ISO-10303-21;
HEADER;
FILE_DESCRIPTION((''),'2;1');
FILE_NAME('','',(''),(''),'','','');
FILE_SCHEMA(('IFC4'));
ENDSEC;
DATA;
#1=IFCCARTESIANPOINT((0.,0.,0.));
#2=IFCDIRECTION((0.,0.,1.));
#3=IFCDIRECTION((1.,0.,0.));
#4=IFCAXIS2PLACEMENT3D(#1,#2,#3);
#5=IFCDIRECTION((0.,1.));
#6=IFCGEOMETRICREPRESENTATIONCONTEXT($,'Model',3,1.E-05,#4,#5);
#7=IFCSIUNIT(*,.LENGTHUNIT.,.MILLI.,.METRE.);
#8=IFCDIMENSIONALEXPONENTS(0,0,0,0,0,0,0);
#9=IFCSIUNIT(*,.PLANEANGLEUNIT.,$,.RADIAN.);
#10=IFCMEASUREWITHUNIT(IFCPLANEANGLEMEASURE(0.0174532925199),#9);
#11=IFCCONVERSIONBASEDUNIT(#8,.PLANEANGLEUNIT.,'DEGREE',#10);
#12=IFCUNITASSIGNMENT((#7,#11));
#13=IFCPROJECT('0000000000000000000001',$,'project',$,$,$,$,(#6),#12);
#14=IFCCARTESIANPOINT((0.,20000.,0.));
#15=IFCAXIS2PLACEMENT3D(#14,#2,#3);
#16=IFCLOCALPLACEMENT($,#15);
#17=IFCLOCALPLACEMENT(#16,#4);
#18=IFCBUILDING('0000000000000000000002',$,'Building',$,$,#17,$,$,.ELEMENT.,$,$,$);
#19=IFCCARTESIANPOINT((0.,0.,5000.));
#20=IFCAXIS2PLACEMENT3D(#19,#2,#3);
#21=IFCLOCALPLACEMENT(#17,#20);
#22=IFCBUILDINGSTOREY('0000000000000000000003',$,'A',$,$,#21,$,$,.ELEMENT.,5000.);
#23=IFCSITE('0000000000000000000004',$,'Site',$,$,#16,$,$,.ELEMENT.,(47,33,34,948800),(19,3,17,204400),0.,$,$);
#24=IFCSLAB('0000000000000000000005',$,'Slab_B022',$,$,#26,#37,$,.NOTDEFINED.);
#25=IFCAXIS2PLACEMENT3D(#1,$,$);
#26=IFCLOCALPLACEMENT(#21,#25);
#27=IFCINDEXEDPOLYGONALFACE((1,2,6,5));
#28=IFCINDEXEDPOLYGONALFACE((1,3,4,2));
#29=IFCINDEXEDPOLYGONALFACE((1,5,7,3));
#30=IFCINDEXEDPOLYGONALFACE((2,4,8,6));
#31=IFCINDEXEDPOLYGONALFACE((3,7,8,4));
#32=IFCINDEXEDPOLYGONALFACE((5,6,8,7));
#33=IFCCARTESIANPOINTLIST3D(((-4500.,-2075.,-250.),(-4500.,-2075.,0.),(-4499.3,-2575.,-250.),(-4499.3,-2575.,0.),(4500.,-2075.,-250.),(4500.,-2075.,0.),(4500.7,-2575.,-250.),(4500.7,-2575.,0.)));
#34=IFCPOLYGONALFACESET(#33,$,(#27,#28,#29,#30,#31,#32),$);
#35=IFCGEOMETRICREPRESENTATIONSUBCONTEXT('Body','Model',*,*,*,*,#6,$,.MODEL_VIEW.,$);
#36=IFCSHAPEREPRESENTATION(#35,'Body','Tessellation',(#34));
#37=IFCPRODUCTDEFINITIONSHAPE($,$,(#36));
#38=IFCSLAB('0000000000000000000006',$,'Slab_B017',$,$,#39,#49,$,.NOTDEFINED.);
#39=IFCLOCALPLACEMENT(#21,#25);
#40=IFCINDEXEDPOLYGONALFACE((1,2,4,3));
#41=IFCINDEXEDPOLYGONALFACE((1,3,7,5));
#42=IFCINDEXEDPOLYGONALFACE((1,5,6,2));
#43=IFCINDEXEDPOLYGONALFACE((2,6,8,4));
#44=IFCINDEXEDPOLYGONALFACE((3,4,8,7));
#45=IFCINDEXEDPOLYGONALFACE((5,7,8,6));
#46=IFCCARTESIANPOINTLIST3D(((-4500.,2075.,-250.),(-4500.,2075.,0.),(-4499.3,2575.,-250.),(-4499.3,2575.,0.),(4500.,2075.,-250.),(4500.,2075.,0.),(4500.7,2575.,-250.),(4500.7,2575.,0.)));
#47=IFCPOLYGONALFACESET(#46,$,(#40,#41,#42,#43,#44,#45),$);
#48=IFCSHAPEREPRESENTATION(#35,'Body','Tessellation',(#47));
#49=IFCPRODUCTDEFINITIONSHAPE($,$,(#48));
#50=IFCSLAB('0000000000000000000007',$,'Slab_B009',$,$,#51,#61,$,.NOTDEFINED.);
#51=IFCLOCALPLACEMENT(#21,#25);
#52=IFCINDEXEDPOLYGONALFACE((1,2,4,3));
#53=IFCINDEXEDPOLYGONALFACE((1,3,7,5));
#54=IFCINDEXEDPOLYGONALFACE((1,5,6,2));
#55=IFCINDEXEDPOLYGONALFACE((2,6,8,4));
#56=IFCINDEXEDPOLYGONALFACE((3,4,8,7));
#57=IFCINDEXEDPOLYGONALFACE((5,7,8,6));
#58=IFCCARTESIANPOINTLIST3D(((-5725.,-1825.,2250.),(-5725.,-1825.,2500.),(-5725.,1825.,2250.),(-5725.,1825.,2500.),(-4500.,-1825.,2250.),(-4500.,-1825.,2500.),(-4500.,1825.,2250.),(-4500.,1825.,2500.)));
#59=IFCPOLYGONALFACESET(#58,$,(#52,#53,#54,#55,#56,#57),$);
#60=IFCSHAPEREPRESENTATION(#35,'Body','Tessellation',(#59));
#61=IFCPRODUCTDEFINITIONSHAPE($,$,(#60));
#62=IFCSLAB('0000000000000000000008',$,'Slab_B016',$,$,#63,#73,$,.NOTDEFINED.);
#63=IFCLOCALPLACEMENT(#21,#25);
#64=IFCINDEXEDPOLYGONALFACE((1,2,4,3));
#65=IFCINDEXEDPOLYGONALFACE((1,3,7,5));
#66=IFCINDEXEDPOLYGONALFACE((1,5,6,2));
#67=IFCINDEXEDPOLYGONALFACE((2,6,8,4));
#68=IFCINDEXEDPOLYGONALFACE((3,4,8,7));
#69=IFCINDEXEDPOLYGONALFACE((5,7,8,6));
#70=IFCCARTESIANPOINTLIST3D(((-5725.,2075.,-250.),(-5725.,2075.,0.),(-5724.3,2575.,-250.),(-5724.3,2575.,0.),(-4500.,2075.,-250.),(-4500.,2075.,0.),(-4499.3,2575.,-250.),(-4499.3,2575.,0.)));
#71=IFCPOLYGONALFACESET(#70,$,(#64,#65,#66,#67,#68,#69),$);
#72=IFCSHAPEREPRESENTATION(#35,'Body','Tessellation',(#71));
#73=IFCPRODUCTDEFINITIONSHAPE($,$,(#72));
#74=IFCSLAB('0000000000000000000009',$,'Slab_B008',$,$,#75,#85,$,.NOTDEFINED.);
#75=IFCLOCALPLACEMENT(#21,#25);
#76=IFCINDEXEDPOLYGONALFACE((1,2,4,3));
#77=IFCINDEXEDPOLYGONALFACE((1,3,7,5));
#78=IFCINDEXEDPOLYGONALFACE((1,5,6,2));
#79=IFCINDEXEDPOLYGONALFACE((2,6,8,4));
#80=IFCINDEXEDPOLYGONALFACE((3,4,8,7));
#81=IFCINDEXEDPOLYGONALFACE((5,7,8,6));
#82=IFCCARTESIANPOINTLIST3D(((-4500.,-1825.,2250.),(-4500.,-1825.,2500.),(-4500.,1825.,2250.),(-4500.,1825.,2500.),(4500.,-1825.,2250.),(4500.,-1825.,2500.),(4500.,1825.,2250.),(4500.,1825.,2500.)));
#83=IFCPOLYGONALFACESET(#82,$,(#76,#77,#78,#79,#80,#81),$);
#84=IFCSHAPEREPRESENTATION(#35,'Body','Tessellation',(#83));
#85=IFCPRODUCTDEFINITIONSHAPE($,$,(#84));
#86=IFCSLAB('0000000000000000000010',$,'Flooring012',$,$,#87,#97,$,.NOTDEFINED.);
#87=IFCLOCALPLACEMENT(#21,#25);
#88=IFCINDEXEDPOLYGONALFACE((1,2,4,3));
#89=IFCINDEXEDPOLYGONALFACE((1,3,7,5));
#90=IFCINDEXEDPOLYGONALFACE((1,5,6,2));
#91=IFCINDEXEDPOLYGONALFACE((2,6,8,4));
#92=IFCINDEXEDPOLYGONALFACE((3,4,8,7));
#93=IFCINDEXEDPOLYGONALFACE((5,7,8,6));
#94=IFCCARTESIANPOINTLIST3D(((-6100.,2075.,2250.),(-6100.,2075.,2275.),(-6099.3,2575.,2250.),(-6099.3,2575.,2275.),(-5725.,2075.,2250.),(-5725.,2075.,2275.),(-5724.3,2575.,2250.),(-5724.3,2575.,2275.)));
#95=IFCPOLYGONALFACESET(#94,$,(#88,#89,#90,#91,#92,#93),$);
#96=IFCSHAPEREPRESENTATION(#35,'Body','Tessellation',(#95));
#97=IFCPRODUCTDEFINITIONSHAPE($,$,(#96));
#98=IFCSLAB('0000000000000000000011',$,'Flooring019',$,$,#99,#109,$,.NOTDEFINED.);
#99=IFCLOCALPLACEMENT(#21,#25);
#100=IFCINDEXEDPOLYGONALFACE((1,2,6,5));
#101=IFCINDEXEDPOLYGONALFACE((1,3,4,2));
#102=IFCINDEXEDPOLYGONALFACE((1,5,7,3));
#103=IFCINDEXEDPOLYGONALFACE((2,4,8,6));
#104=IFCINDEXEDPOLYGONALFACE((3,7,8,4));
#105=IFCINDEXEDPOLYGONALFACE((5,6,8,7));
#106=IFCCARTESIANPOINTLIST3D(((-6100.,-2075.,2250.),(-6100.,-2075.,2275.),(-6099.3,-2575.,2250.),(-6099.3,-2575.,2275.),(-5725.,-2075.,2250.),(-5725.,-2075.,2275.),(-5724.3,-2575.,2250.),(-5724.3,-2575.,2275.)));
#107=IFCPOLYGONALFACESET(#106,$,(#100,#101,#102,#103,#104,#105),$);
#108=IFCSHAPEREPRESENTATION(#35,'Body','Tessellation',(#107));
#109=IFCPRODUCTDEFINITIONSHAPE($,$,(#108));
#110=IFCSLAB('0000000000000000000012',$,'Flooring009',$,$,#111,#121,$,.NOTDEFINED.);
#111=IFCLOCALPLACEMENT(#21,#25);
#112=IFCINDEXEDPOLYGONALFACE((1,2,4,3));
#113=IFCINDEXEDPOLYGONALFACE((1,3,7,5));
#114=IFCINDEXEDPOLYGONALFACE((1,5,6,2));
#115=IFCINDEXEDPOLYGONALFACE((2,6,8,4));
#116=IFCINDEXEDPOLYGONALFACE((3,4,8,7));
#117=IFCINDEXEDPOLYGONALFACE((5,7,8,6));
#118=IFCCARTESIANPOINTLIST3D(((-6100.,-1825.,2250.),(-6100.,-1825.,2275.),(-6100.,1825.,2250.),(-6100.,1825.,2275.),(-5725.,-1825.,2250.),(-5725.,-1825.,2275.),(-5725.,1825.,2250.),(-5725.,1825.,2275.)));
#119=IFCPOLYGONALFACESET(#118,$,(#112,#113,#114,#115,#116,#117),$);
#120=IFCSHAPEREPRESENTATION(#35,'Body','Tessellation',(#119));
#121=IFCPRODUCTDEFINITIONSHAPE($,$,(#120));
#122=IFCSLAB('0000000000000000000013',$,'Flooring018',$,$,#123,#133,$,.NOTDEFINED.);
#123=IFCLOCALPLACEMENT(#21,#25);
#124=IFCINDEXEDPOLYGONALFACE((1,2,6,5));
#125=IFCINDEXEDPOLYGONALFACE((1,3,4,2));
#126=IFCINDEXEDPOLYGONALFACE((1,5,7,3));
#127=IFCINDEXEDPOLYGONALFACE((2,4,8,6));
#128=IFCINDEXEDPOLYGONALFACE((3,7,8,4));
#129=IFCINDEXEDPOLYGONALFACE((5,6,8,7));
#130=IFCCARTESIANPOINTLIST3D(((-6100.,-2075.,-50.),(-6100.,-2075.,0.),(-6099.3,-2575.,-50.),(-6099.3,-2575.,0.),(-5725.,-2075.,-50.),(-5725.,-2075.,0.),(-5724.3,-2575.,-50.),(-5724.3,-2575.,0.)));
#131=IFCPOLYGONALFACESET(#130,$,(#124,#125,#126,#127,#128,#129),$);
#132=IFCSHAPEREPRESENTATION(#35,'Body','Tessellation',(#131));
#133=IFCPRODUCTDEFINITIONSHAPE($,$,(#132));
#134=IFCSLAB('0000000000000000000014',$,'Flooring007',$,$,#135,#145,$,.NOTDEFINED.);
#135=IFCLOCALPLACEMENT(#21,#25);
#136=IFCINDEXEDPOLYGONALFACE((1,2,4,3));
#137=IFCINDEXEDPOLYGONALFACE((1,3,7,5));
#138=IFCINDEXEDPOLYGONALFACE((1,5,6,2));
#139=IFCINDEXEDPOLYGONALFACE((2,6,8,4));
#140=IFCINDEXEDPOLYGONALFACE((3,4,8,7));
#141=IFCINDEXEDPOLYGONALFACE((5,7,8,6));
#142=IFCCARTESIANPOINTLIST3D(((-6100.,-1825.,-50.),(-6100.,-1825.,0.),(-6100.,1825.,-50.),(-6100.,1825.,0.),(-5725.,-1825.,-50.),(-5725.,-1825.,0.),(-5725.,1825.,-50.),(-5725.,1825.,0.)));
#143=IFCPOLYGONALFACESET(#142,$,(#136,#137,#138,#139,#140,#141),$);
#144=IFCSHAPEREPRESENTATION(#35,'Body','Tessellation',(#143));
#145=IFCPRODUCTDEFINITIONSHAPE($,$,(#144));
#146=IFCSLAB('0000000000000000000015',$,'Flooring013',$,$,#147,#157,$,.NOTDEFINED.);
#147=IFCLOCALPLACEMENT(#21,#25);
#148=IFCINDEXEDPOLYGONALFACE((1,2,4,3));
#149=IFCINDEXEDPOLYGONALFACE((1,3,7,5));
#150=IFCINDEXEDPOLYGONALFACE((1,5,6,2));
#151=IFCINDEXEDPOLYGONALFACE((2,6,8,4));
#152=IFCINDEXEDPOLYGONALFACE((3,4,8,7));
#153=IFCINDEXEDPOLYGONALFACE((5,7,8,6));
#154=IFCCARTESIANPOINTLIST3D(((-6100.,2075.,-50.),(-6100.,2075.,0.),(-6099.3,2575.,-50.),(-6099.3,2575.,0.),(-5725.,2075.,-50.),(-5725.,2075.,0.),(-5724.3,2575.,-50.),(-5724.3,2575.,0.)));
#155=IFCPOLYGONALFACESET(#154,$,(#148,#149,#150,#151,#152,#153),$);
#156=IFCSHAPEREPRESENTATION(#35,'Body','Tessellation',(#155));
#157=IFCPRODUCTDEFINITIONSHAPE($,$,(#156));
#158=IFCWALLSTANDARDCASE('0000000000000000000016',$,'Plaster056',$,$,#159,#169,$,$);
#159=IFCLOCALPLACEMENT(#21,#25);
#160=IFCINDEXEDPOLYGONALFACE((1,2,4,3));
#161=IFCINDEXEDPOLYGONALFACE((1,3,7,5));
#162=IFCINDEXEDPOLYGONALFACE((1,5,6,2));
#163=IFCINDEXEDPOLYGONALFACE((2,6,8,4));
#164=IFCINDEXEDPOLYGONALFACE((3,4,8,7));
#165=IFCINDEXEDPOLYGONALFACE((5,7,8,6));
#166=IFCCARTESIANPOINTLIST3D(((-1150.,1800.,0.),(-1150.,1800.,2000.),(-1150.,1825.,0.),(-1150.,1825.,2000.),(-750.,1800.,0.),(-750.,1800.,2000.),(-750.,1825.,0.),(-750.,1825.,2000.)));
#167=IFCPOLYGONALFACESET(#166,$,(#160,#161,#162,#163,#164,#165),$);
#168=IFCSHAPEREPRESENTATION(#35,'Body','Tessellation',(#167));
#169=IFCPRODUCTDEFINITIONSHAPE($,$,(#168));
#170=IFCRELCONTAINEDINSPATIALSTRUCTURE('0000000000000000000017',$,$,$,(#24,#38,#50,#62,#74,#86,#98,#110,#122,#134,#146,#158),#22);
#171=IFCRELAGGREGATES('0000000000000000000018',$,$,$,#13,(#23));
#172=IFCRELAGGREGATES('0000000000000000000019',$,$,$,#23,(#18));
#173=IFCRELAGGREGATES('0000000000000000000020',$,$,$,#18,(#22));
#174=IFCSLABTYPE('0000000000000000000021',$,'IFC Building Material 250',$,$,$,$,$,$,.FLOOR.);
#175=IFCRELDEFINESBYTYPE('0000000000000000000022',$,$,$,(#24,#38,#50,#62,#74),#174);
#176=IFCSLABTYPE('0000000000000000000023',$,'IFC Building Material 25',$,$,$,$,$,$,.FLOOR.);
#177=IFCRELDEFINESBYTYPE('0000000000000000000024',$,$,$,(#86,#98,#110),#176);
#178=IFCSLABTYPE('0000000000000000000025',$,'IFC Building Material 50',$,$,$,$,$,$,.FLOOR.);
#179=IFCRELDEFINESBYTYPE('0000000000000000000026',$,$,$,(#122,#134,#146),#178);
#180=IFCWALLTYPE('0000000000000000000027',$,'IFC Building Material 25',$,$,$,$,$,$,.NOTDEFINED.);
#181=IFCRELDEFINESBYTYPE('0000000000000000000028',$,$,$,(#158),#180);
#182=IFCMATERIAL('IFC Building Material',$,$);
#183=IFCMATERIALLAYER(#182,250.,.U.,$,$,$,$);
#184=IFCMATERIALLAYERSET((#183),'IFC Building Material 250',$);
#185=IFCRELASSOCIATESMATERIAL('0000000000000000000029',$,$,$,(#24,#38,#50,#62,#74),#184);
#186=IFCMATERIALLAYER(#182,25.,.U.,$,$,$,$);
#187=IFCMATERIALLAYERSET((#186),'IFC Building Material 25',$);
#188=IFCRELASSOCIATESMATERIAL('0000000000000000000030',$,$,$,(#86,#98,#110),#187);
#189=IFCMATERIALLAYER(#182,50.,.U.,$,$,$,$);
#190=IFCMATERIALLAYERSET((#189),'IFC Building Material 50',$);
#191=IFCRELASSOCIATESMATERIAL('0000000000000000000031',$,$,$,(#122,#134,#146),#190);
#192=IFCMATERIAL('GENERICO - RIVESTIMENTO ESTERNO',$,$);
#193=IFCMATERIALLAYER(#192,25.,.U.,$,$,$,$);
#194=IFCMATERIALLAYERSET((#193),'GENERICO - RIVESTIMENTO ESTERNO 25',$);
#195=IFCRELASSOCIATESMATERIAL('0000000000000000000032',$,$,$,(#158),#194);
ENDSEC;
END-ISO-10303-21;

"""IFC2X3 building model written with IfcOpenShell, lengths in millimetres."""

from ifc_helpers import new_model, entity, si_unit, converted_unit, direction, frame, origin_with_axes, place, context, subcontext, project, spatial, polyline, outline, extrude, material, layer, layer_set, layer_usage, type_object, element, save


model = new_model("IFC2X3")

# Units and contexts
model_context = context("Model", 3, precision=1e-05, world=origin_with_axes(), true_north=direction((0.0, 1.0)))
body_context = subcontext(model_context, "Body", "Model", "MODEL_VIEW")
ifc_project = project(units=[si_unit("LENGTHUNIT", "METRE", prefix="MILLI"), converted_unit("PLANEANGLEUNIT", "DEGREE", entity("IfcPlaneAngleMeasure", 0.0174532925199), si_unit("PLANEANGLEUNIT", "RADIAN"), dimensions=[0, 0, 0, 0, 0, 0, 0])], contexts=[model_context])

# Site, building, storey
site_placement = place(None, frame((0.0, 20000.0, 0.0), z_axis=(0.0, 0.0, 1.0), x_axis=(1.0, 0.0, 0.0)))
site = spatial("IfcSite", under=ifc_project, at=site_placement, Name="Site", CompositionType="ELEMENT", RefLatitude=(47, 33, 34, 948800), RefLongitude=(19, 3, 17, 204400), RefElevation=0.0)
building_placement = place(site_placement, origin_with_axes())
building = spatial("IfcBuilding", under=site, at=building_placement, Name="Building", CompositionType="ELEMENT")
storey_placement = place(building_placement, frame((0.0, 0.0, 5000.0), z_axis=(0.0, 0.0, 1.0), x_axis=(1.0, 0.0, 0.0)))
storey = spatial("IfcBuildingStorey", under=building, at=storey_placement, Name="A", CompositionType="ELEMENT", Elevation=5000.0)

# Shared definitions
ifc_material_1 = material(Name="GENERICO - RIVESTIMENTO ESTERNO")

# Slabs
ifc_material_2 = material(Name="IFC Building Material")
ifc_layer_1 = layer(ifc_material_2, 250.0, ventilated="UNKNOWN")
ifc_layer_set_1 = layer_set([ifc_layer_1], Name="IFC Building Material 250")
slab_type_1 = type_object("IfcSlabType", Name="IFC Building Material 250", PredefinedType="FLOOR")
ifc_layer_usage_1 = layer_usage(ifc_layer_set_1, "AXIS3", "NEGATIVE", 250.0)
slab_1_placement = place(storey_placement, frame((-4500.0, -2075.0, 0.0), z_axis=(0.0, 0.0, 1.0), x_axis=(1.0, 0.0, 0.0)))
element("IfcSlab", 1, at=slab_1_placement, inside=storey, type_object=slab_type_1, material=ifc_layer_usage_1, Name="Slab_B022", PredefinedType="NOTDEFINED", context=body_context, shape_type="SweptSolid", body=[
    extrude(outline(polyline([(0.0, 0.0), (0.7, -500.0), (9000.7, -500.0), (9000.0, 0.0), (0.0, 0.0)])), frame((0.0, 0.0, -250.0), z_axis=(0.0, 0.0, 1.0), x_axis=(1.0, 0.0, 0.0)), (0.0, 0.0, 1.0), 250.0),
])
ifc_layer_usage_2 = layer_usage(ifc_layer_set_1, "AXIS3", "NEGATIVE", 250.0)
slab_2_placement = place(storey_placement, frame((-4500.0, 2075.0, 0.0), z_axis=(0.0, 0.0, 1.0), x_axis=(1.0, 0.0, 0.0)))
element("IfcSlab", 2, at=slab_2_placement, inside=storey, type_object=slab_type_1, material=ifc_layer_usage_2, Name="Slab_B017", PredefinedType="NOTDEFINED", context=body_context, shape_type="SweptSolid", body=[
    extrude(outline(polyline([(0.0, 0.0), (9000.0, 0.0), (9000.7, 500.0), (0.7, 500.0), (0.0, 0.0)])), frame((0.0, 0.0, -250.0), z_axis=(0.0, 0.0, 1.0), x_axis=(1.0, 0.0, 0.0)), (0.0, 0.0, 1.0), 250.0),
])
ifc_layer_usage_3 = layer_usage(ifc_layer_set_1, "AXIS3", "NEGATIVE", 250.0)
slab_3_placement = place(storey_placement, frame((-5725.0, -1825.0, 2500.0), z_axis=(0.0, 0.0, 1.0), x_axis=(1.0, 0.0, 0.0)))
element("IfcSlab", 3, at=slab_3_placement, inside=storey, type_object=slab_type_1, material=ifc_layer_usage_3, Name="Slab_B009", PredefinedType="NOTDEFINED", context=body_context, shape_type="SweptSolid", body=[
    extrude(outline(polyline([(0.0, 0.0), (1225.0, 0.0), (1225.0, 3650.0), (0.0, 3650.0), (0.0, 0.0)])), frame((0.0, 0.0, -250.0), z_axis=(0.0, 0.0, 1.0), x_axis=(1.0, 0.0, 0.0)), (0.0, 0.0, 1.0), 250.0),
])
ifc_layer_usage_4 = layer_usage(ifc_layer_set_1, "AXIS3", "NEGATIVE", 250.0)
slab_4_placement = place(storey_placement, frame((-5725.0, 2075.0, 0.0), z_axis=(0.0, 0.0, 1.0), x_axis=(1.0, 0.0, 0.0)))
element("IfcSlab", 4, at=slab_4_placement, inside=storey, type_object=slab_type_1, material=ifc_layer_usage_4, Name="Slab_B016", PredefinedType="NOTDEFINED", context=body_context, shape_type="SweptSolid", body=[
    extrude(outline(polyline([(0.0, 0.0), (1225.0, 0.0), (1225.7, 500.0), (0.7, 500.0), (0.0, 0.0)])), frame((0.0, 0.0, -250.0), z_axis=(0.0, 0.0, 1.0), x_axis=(1.0, 0.0, 0.0)), (0.0, 0.0, 1.0), 250.0),
])
ifc_layer_usage_5 = layer_usage(ifc_layer_set_1, "AXIS3", "NEGATIVE", 250.0)
slab_5_placement = place(storey_placement, frame((-4500.0, -1825.0, 2500.0), z_axis=(0.0, 0.0, 1.0), x_axis=(1.0, 0.0, 0.0)))
element("IfcSlab", 5, at=slab_5_placement, inside=storey, type_object=slab_type_1, material=ifc_layer_usage_5, Name="Slab_B008", PredefinedType="NOTDEFINED", context=body_context, shape_type="SweptSolid", body=[
    extrude(outline(polyline([(0.0, 0.0), (9000.0, 0.0), (9000.0, 3650.0), (0.0, 3650.0), (0.0, 0.0)])), frame((0.0, 0.0, -250.0), z_axis=(0.0, 0.0, 1.0), x_axis=(1.0, 0.0, 0.0)), (0.0, 0.0, 1.0), 250.0),
])
ifc_layer_2 = layer(ifc_material_2, 25.0, ventilated="UNKNOWN")
ifc_layer_set_2 = layer_set([ifc_layer_2], Name="IFC Building Material 25")
ifc_layer_usage_6 = layer_usage(ifc_layer_set_2, "AXIS3", "NEGATIVE", 25.0)
slab_type_2 = type_object("IfcSlabType", Name="IFC Building Material 25", PredefinedType="FLOOR")
slab_6_placement = place(storey_placement, frame((-6100.0, 2075.0, 2275.0), z_axis=(0.0, 0.0, 1.0), x_axis=(1.0, 0.0, 0.0)))
element("IfcSlab", 6, at=slab_6_placement, inside=storey, type_object=slab_type_2, material=ifc_layer_usage_6, Name="Flooring012", PredefinedType="NOTDEFINED", context=body_context, shape_type="SweptSolid", body=[
    extrude(outline(polyline([(0.0, 0.0), (375.0, 0.0), (375.7, 500.0), (0.7, 500.0), (0.0, 0.0)])), frame((0.0, 0.0, -25.0), z_axis=(0.0, 0.0, 1.0), x_axis=(1.0, 0.0, 0.0)), (0.0, 0.0, 1.0), 25.0),
])
ifc_layer_usage_7 = layer_usage(ifc_layer_set_2, "AXIS3", "NEGATIVE", 25.0)
slab_7_placement = place(storey_placement, frame((-6100.0, -2075.0, 2275.0), z_axis=(0.0, 0.0, 1.0), x_axis=(1.0, 0.0, 0.0)))
element("IfcSlab", 7, at=slab_7_placement, inside=storey, type_object=slab_type_2, material=ifc_layer_usage_7, Name="Flooring019", PredefinedType="NOTDEFINED", context=body_context, shape_type="SweptSolid", body=[
    extrude(outline(polyline([(0.0, 0.0), (0.7, -500.0), (375.7, -500.0), (375.0, 0.0), (0.0, 0.0)])), frame((0.0, 0.0, -25.0), z_axis=(0.0, 0.0, 1.0), x_axis=(1.0, 0.0, 0.0)), (0.0, 0.0, 1.0), 25.0),
])
ifc_layer_usage_8 = layer_usage(ifc_layer_set_2, "AXIS3", "NEGATIVE", 25.0)
slab_8_placement = place(storey_placement, frame((-6100.0, 1825.0, 2275.0), z_axis=(0.0, 0.0, 1.0), x_axis=(1.0, 0.0, 0.0)))
element("IfcSlab", 8, at=slab_8_placement, inside=storey, type_object=slab_type_2, material=ifc_layer_usage_8, Name="Flooring009", PredefinedType="NOTDEFINED", context=body_context, shape_type="SweptSolid", body=[
    extrude(outline(polyline([(0.0, 0.0), (0.0, -3650.0), (375.0, -3650.0), (375.0, 0.0), (0.0, 0.0)])), frame((0.0, 0.0, -25.0), z_axis=(0.0, 0.0, 1.0), x_axis=(1.0, 0.0, 0.0)), (0.0, 0.0, 1.0), 25.0),
])
ifc_layer_3 = layer(ifc_material_2, 50.0, ventilated="UNKNOWN")
ifc_layer_set_3 = layer_set([ifc_layer_3], Name="IFC Building Material 50")
ifc_layer_usage_9 = layer_usage(ifc_layer_set_3, "AXIS3", "NEGATIVE", 50.0)
slab_type_3 = type_object("IfcSlabType", Name="IFC Building Material 50", PredefinedType="FLOOR")
slab_9_placement = place(storey_placement, frame((-6100.0, -2075.0, 0.0), z_axis=(0.0, 0.0, 1.0), x_axis=(1.0, 0.0, 0.0)))
element("IfcSlab", 9, at=slab_9_placement, inside=storey, type_object=slab_type_3, material=ifc_layer_usage_9, Name="Flooring018", PredefinedType="NOTDEFINED", context=body_context, shape_type="SweptSolid", body=[
    extrude(outline(polyline([(0.0, 0.0), (0.7, -500.0), (375.7, -500.0), (375.0, 0.0), (0.0, 0.0)])), frame((0.0, 0.0, -50.0), z_axis=(0.0, 0.0, 1.0), x_axis=(1.0, 0.0, 0.0)), (0.0, 0.0, 1.0), 50.0),
])
ifc_layer_usage_10 = layer_usage(ifc_layer_set_3, "AXIS3", "NEGATIVE", 50.0)
slab_10_placement = place(storey_placement, frame((-6100.0, 1825.0, 0.0), z_axis=(0.0, 0.0, 1.0), x_axis=(1.0, 0.0, 0.0)))
element("IfcSlab", 10, at=slab_10_placement, inside=storey, type_object=slab_type_3, material=ifc_layer_usage_10, Name="Flooring007", PredefinedType="NOTDEFINED", context=body_context, shape_type="SweptSolid", body=[
    extrude(outline(polyline([(0.0, 0.0), (0.0, -3650.0), (375.0, -3650.0), (375.0, 0.0), (0.0, 0.0)])), frame((0.0, 0.0, -50.0), z_axis=(0.0, 0.0, 1.0), x_axis=(1.0, 0.0, 0.0)), (0.0, 0.0, 1.0), 50.0),
])
ifc_layer_usage_11 = layer_usage(ifc_layer_set_3, "AXIS3", "NEGATIVE", 50.0)
slab_11_placement = place(storey_placement, frame((-6100.0, 2075.0, 0.0), z_axis=(0.0, 0.0, 1.0), x_axis=(1.0, 0.0, 0.0)))
element("IfcSlab", 11, at=slab_11_placement, inside=storey, type_object=slab_type_3, material=ifc_layer_usage_11, Name="Flooring013", PredefinedType="NOTDEFINED", context=body_context, shape_type="SweptSolid", body=[
    extrude(outline(polyline([(0.0, 0.0), (375.0, 0.0), (375.7, 500.0), (0.7, 500.0), (0.0, 0.0)])), frame((0.0, 0.0, -50.0), z_axis=(0.0, 0.0, 1.0), x_axis=(1.0, 0.0, 0.0)), (0.0, 0.0, 1.0), 50.0),
])

# Wall
ifc_layer_4 = layer(ifc_material_1, 25.0, ventilated="UNKNOWN")
ifc_layer_set_4 = layer_set([ifc_layer_4], Name="GENERICO - RIVESTIMENTO ESTERNO 25")
ifc_layer_usage_12 = layer_usage(ifc_layer_set_4, "AXIS2", "POSITIVE", 0.0)
wall_type_1 = type_object("IfcWallType", Name="IFC Building Material 25", PredefinedType="NOTDEFINED")
wall_1_placement = place(storey_placement, frame((-1150.0, 1800.0, 0.0), z_axis=(0.0, 0.0, 1.0), x_axis=(1.0, 0.0, 0.0)))
element("IfcWallStandardCase", 12, at=wall_1_placement, inside=storey, type_object=wall_type_1, material=ifc_layer_usage_12, Name="Plaster056", context=body_context, shape_type="SweptSolid", body=[
    extrude(outline(polyline([(0.0, 0.0), (400.0, 0.0), (400.0, 25.0), (0.0, 25.0), (0.0, 0.0)])), origin_with_axes(), (0.0, 0.0, 1.0), 2000.0),
])

save(model, "model.ifc")
